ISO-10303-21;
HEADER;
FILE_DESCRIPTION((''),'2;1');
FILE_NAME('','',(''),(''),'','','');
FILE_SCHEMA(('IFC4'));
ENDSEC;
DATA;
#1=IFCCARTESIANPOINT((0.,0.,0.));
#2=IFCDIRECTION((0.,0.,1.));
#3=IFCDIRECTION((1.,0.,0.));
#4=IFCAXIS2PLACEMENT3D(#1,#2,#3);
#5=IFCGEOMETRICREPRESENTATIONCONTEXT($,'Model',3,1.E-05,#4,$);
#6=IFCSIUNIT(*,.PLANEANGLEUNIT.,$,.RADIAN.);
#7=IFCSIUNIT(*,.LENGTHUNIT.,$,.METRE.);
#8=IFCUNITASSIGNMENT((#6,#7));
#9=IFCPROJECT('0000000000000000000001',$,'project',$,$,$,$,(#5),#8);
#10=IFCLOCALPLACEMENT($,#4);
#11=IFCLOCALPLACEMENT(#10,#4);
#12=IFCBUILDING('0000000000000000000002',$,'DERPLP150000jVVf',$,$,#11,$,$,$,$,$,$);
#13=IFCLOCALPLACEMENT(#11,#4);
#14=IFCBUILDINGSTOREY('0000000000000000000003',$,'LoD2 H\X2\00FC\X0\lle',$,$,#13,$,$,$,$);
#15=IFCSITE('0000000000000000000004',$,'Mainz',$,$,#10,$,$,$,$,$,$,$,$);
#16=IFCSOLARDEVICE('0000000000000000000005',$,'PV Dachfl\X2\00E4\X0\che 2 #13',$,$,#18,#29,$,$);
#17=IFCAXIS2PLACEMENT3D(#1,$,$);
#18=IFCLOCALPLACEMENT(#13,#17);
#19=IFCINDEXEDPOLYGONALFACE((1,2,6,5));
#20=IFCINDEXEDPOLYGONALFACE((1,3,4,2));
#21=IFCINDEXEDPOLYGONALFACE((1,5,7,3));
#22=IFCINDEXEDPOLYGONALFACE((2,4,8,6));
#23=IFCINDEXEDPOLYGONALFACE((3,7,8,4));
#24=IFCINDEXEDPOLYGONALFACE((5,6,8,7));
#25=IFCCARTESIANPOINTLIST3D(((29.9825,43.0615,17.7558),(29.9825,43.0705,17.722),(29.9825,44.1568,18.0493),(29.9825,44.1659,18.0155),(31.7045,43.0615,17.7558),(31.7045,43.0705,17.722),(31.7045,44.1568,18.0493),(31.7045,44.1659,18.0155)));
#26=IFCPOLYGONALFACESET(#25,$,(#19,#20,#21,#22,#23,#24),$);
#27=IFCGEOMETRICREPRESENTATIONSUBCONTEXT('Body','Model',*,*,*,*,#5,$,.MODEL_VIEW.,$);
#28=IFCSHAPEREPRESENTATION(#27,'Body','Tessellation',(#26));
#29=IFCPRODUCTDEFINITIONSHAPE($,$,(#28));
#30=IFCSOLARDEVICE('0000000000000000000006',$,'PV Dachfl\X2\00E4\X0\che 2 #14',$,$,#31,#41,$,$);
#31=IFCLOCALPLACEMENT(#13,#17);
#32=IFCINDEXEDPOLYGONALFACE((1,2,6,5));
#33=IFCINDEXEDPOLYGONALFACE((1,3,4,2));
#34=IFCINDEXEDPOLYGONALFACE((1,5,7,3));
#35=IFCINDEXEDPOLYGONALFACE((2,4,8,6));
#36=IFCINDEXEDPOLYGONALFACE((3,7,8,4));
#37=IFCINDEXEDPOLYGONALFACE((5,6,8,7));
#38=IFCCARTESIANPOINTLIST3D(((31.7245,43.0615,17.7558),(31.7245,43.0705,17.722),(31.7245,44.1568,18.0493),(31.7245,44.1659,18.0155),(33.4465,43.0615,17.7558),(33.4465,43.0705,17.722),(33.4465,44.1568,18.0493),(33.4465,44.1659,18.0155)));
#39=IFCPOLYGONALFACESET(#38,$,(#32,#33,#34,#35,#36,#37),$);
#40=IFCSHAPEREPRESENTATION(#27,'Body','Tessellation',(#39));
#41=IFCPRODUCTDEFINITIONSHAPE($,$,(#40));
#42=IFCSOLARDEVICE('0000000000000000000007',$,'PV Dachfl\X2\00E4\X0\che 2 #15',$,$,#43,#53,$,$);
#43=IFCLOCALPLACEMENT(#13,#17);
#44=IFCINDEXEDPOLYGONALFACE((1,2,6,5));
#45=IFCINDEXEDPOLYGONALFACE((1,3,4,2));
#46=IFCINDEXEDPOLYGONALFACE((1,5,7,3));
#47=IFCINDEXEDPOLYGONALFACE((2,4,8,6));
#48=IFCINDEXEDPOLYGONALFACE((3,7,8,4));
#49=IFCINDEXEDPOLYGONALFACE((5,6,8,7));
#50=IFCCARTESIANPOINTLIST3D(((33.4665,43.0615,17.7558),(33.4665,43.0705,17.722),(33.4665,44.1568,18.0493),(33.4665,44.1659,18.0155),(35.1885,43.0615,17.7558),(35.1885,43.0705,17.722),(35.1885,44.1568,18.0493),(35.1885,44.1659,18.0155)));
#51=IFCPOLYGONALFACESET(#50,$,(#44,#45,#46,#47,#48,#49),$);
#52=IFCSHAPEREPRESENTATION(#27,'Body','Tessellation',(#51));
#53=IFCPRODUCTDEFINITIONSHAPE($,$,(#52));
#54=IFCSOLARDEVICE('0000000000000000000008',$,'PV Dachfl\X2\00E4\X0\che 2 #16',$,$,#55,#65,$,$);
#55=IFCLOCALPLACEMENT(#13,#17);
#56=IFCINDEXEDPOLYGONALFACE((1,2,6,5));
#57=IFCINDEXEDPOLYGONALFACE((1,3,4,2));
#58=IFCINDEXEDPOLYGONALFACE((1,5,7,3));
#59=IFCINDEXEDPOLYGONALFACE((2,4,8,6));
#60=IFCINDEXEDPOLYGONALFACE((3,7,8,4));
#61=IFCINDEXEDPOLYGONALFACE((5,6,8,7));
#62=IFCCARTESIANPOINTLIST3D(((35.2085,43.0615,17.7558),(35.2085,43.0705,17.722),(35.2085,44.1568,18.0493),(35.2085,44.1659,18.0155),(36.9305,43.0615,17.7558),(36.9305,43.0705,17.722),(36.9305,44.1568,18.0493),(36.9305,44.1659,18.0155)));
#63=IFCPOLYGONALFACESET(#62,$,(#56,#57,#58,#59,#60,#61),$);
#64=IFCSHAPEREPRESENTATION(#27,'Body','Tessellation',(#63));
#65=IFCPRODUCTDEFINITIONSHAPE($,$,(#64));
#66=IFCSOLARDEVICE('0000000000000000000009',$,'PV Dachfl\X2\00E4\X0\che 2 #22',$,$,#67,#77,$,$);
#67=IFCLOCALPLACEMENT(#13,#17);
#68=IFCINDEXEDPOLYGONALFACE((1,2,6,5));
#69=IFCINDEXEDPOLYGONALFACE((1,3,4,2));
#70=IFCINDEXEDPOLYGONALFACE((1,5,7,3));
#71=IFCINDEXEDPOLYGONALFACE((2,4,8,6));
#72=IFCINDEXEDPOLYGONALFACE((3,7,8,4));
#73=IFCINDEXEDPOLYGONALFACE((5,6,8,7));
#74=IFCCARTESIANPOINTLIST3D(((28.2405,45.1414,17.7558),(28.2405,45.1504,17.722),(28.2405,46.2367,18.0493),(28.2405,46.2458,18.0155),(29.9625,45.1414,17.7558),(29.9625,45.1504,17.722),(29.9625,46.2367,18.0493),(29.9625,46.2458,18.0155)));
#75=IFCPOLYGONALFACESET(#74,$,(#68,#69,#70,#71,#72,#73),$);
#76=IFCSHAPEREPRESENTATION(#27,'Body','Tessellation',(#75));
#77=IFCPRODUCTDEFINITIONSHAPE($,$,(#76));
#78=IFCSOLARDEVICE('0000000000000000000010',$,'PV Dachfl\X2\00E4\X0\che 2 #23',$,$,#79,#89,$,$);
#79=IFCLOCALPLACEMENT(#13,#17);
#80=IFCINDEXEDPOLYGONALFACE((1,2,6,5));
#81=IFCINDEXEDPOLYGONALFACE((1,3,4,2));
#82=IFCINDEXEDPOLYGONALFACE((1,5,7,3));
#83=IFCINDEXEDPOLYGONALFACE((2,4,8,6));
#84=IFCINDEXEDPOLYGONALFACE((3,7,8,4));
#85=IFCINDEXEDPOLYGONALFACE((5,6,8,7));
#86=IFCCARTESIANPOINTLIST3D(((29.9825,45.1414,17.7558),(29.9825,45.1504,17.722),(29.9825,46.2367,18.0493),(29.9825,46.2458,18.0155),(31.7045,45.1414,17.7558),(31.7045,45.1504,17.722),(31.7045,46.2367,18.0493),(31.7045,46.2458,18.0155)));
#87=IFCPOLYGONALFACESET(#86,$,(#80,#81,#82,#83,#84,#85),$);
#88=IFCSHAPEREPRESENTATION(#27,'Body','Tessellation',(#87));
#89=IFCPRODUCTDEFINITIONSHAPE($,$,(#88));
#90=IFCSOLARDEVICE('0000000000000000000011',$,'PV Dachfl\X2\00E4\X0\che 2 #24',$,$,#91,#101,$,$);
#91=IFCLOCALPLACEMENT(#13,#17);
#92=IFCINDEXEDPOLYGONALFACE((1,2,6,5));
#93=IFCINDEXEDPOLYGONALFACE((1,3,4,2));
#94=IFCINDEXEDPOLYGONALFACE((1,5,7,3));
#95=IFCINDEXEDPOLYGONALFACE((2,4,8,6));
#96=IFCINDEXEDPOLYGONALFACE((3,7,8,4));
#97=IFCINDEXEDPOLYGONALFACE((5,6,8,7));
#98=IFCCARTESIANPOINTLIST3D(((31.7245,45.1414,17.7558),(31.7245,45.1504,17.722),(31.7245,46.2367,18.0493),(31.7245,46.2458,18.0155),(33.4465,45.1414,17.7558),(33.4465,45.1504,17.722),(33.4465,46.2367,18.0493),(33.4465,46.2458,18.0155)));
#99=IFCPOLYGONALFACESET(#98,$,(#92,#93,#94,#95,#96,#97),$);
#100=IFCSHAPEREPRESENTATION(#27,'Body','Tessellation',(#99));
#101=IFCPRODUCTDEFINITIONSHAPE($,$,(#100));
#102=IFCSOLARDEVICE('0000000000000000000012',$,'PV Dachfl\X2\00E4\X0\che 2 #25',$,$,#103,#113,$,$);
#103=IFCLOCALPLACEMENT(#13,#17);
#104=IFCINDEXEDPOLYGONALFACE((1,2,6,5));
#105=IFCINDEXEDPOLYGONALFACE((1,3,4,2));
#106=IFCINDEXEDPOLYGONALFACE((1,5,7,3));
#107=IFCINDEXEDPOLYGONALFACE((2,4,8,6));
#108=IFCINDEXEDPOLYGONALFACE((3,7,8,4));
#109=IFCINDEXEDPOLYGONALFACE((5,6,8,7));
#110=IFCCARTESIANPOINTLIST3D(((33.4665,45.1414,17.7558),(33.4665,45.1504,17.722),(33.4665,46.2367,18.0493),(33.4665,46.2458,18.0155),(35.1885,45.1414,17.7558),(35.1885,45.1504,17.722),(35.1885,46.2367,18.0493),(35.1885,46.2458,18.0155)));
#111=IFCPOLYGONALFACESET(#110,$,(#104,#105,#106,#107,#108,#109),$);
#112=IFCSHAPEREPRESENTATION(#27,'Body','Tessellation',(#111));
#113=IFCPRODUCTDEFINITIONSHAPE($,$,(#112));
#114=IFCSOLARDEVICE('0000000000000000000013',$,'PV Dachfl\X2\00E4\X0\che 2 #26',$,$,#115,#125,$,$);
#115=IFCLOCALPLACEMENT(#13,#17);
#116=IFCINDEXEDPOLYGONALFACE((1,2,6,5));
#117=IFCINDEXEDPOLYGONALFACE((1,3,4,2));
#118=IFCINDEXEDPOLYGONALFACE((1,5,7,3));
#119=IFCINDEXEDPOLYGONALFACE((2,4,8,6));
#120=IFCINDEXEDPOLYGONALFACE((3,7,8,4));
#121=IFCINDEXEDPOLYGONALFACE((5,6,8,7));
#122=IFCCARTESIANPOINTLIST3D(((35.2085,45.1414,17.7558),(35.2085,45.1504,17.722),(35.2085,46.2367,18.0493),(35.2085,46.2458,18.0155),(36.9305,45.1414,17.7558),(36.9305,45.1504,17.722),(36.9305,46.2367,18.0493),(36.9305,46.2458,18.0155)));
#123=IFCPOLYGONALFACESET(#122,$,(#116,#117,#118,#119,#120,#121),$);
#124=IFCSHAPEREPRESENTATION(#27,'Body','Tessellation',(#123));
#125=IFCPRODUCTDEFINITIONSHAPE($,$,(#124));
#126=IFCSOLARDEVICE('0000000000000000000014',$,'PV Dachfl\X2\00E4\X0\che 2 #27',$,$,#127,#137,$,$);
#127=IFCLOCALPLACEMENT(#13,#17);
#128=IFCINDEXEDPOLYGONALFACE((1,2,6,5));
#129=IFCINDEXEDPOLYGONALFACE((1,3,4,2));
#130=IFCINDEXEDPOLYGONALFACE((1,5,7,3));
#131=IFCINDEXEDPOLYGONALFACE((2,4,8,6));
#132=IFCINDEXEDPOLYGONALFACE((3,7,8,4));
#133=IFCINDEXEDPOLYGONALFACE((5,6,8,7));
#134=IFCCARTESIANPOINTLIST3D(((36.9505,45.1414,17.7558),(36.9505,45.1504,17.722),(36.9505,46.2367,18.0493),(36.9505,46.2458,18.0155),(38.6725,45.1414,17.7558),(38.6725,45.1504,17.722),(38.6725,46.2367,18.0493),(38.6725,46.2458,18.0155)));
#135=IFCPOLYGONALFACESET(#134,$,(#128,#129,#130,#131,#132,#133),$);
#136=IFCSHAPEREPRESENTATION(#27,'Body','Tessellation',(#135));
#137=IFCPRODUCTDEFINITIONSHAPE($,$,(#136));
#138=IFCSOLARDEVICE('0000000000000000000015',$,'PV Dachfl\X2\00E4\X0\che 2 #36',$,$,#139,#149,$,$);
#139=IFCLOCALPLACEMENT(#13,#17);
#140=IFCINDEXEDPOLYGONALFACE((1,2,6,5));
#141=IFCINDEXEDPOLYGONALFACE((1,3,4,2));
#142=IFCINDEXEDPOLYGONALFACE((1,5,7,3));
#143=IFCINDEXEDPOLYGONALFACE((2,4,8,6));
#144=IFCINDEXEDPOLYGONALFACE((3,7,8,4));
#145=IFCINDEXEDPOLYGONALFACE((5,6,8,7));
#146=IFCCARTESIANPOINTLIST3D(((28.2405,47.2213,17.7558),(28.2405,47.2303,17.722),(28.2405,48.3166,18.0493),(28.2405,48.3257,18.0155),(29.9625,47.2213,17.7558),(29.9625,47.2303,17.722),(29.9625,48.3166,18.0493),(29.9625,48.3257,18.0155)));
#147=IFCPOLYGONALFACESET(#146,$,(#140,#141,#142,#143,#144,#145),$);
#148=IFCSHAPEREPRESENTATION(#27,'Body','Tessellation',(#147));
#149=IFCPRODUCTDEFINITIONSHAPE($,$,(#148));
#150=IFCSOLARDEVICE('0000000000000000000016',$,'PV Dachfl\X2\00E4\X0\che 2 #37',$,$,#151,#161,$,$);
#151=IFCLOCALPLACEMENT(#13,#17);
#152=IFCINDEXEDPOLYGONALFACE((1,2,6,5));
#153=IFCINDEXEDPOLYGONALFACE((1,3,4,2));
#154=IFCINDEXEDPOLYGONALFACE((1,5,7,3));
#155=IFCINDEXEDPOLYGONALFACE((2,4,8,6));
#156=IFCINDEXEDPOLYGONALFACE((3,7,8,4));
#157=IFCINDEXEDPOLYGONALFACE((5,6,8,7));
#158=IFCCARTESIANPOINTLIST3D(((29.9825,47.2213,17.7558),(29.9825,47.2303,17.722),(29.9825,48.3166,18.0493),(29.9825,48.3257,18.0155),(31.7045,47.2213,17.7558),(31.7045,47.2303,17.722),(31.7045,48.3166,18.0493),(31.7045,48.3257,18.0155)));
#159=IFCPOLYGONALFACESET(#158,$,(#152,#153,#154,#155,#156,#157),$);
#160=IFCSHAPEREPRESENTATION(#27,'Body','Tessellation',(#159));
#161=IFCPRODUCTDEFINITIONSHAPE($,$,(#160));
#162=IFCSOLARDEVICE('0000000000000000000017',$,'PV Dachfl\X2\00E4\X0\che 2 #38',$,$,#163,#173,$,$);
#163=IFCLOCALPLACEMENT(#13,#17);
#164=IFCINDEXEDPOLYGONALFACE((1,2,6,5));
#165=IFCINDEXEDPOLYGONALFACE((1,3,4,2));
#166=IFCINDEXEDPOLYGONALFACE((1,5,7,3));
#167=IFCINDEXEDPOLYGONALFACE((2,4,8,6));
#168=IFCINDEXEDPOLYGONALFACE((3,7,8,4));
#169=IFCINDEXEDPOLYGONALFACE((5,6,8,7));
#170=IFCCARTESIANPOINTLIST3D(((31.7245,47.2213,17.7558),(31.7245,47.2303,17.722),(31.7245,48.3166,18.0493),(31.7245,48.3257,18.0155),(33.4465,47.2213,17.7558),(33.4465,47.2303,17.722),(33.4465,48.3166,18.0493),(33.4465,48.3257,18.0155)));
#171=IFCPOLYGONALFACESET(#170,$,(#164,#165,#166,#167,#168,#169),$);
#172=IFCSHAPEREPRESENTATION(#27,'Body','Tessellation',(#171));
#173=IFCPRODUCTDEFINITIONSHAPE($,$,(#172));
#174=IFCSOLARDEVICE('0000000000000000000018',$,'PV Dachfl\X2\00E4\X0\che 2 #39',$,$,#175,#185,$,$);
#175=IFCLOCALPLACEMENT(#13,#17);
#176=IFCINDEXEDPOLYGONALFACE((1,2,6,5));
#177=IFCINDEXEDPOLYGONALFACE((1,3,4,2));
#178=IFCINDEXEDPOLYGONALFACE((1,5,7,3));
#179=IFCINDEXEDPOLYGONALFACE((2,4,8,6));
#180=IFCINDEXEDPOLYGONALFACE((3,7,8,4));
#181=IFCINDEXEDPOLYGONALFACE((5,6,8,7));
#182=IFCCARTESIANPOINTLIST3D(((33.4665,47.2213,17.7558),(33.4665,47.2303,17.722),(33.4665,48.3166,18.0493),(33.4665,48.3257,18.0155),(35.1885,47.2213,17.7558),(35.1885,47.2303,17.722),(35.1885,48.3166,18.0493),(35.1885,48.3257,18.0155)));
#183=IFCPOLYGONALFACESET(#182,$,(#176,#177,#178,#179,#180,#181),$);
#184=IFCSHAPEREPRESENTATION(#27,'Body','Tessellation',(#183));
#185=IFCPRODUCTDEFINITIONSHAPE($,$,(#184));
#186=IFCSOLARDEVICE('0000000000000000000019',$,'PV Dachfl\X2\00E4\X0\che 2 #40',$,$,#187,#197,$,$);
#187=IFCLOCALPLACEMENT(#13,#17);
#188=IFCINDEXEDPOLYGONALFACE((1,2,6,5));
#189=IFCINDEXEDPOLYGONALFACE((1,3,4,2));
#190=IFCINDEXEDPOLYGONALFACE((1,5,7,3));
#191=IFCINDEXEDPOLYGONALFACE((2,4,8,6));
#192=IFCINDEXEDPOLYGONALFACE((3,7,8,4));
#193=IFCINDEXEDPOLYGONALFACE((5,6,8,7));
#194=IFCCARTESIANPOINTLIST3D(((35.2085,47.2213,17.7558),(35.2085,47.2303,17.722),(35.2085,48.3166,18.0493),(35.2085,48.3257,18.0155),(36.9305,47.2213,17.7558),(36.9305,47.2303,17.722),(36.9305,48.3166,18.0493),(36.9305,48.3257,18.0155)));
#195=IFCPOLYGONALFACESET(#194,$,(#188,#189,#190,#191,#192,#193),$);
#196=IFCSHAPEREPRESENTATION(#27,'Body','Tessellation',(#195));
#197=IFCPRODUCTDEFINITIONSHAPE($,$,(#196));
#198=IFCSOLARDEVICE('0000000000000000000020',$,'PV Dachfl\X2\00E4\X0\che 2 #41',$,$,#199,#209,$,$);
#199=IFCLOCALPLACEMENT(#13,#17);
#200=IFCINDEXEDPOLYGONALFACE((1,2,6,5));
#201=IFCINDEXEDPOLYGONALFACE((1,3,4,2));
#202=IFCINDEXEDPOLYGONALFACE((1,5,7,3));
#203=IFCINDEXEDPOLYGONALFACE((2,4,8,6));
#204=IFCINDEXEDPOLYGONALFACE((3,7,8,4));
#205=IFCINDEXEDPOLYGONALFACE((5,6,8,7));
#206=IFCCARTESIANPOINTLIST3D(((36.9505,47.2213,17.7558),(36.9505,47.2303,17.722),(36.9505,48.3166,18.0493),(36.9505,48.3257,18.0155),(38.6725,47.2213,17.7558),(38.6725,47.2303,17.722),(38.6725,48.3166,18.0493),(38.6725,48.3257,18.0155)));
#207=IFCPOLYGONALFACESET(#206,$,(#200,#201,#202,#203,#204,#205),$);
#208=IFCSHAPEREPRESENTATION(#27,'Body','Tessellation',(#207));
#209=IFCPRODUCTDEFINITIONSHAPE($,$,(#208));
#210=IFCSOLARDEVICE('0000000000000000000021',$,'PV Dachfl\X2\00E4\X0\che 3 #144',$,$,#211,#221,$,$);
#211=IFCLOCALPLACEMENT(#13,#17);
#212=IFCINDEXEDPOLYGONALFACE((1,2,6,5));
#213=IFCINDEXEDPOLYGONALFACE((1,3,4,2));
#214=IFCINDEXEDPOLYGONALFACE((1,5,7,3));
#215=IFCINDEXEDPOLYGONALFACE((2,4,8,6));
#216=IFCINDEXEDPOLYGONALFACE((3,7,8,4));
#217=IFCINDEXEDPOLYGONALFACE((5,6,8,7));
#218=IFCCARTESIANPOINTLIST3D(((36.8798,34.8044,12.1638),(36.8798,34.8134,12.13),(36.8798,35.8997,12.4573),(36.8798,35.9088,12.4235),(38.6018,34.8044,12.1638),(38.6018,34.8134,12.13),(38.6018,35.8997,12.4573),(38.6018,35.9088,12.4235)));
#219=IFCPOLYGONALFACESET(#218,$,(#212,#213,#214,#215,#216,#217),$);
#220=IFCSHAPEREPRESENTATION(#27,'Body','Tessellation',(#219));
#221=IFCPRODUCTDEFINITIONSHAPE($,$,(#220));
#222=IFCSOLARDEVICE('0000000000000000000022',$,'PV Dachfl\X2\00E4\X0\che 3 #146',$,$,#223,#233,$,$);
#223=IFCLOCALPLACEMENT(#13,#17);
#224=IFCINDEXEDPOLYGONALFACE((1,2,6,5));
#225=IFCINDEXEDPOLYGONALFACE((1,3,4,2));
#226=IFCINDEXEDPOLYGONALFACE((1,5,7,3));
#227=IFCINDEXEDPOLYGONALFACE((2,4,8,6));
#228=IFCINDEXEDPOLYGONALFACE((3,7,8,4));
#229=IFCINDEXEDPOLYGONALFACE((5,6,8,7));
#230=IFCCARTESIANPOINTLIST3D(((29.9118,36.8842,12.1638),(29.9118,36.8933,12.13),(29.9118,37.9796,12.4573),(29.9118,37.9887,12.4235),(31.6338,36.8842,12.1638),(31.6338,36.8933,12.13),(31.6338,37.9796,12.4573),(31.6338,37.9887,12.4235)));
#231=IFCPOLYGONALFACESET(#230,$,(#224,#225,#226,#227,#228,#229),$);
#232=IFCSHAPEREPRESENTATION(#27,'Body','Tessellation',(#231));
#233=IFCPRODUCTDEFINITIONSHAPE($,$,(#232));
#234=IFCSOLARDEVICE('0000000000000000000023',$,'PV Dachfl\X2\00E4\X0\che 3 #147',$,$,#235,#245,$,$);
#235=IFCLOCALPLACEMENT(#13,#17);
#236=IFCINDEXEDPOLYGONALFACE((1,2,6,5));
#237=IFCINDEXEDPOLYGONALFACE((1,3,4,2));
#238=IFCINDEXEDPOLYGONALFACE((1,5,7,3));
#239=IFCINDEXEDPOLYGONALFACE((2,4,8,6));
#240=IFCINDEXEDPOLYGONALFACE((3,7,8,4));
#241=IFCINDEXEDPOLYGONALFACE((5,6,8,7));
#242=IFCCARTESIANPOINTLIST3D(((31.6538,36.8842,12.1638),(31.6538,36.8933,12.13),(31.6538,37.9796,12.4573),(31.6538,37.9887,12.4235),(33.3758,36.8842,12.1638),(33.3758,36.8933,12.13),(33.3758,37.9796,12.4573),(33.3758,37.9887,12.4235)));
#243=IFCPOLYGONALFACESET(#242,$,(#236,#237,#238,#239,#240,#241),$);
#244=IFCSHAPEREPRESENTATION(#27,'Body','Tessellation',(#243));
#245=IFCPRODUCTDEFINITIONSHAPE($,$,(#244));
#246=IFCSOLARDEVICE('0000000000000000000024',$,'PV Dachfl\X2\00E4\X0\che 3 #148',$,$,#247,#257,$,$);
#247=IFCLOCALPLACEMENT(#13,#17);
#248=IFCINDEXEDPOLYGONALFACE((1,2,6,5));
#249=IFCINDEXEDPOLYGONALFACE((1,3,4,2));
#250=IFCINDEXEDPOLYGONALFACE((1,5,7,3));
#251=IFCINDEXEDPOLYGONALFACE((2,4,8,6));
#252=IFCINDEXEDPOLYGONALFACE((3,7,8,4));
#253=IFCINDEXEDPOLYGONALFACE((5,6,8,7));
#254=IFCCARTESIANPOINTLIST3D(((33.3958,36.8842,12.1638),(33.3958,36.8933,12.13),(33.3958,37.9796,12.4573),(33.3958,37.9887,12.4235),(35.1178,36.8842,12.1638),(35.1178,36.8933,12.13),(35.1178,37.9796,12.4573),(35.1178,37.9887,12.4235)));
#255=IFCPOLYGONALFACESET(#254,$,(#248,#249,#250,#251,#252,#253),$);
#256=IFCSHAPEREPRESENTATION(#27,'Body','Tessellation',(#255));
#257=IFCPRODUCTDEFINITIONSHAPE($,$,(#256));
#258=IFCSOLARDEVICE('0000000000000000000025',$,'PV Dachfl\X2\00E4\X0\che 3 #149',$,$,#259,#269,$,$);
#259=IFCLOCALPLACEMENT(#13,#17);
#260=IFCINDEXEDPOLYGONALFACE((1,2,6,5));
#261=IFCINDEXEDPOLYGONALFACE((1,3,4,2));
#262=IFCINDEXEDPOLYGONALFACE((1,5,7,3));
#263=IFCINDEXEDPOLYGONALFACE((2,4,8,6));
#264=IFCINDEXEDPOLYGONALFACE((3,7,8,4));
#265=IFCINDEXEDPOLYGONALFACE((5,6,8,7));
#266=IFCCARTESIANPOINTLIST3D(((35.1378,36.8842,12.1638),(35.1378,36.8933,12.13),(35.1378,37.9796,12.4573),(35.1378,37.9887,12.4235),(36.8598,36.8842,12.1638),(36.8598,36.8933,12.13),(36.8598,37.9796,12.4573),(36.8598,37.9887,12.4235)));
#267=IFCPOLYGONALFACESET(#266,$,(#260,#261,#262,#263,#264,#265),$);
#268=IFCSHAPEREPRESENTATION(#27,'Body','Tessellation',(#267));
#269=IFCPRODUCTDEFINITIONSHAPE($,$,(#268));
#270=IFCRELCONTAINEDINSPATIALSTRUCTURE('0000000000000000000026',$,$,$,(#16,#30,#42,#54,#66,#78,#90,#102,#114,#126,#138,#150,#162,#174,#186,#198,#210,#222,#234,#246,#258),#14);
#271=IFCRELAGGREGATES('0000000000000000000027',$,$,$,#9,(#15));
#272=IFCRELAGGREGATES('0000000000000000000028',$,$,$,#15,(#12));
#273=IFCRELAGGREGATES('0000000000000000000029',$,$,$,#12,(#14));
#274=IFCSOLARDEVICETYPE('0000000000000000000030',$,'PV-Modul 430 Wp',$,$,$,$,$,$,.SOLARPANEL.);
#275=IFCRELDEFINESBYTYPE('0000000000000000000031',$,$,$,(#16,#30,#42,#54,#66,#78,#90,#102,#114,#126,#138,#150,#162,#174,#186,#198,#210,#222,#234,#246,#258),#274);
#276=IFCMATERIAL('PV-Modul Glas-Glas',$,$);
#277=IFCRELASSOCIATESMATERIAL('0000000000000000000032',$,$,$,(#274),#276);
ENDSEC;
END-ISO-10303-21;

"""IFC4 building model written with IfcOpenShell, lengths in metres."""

from ifc_helpers import new_model, si_unit, frame, frame_2d, origin, origin_with_axes, place, context, subcontext, project, spatial, rectangle, extrude, source, transform, mapped, material, type_object, type_shapes, element, save


model = new_model("IFC4")

# Units and contexts
model_context = context("Model", 3, precision=1e-05, world=origin_with_axes())
body_context = subcontext(model_context, "Body", "Model", "MODEL_VIEW")
ifc_project = project(units=[si_unit("PLANEANGLEUNIT", "RADIAN"), si_unit("LENGTHUNIT", "METRE")], contexts=[model_context])

# Site, building, storey
site_placement = place(None, origin_with_axes())
site = spatial("IfcSite", under=ifc_project, at=site_placement, Name="Mainz")
building_placement = place(site_placement, origin_with_axes())
building = spatial("IfcBuilding", under=site, at=building_placement, Name="DERPLP150000jVVf")
storey_placement = place(building_placement, origin_with_axes())
storey = spatial("IfcBuildingStorey", under=building, at=storey_placement, Name="LoD2 Hülle")

# Solar devices
ifc_material = material(Name="PV-Modul Glas-Glas")
solar_device_type = type_object("IfcSolarDeviceType", Name="PV-Modul 430 Wp", PredefinedType="SOLARPANEL", material=ifc_material)
shared_shape = source(origin_with_axes(), body_context, "Body", "SweptSolid", [
    extrude(rectangle(XDim=1.722, YDim=1.134, at=frame_2d((0.861, 0.567))), origin(), (0.0, 0.0, 1.0), 0.035),
])
type_shapes(solar_device_type, [shared_shape])
for number, where, z_axis, x_axis, name in (
    (1, (29.9825, 43.0705, 17.722), (0.0, -0.258819, 0.965926), (1.0, 0.0, 0.0), "PV Dachfläche 2 #13"),
    (2, (31.7245, 43.0705, 17.722), (0.0, -0.258819, 0.965926), (1.0, 0.0, 0.0), "PV Dachfläche 2 #14"),
    (3, (33.4665, 43.0705, 17.722), (0.0, -0.258819, 0.965926), (1.0, 0.0, 0.0), "PV Dachfläche 2 #15"),
    (4, (35.2085, 43.0705, 17.722), (0.0, -0.258819, 0.965926), (1.0, 0.0, 0.0), "PV Dachfläche 2 #16"),
    (5, (28.2405, 45.1504, 17.722), (0.0, -0.258819, 0.965926), (1.0, 0.0, 0.0), "PV Dachfläche 2 #22"),
    (6, (29.9825, 45.1504, 17.722), (0.0, -0.258819, 0.965926), (1.0, 0.0, 0.0), "PV Dachfläche 2 #23"),
    (7, (31.7245, 45.1504, 17.722), (0.0, -0.258819, 0.965926), (1.0, 0.0, 0.0), "PV Dachfläche 2 #24"),
    (8, (33.4665, 45.1504, 17.722), (0.0, -0.258819, 0.965926), (1.0, 0.0, 0.0), "PV Dachfläche 2 #25"),
    (9, (35.2085, 45.1504, 17.722), (0.0, -0.258819, 0.965926), (1.0, 0.0, 0.0), "PV Dachfläche 2 #26"),
    (10, (36.9505, 45.1504, 17.722), (0.0, -0.258819, 0.965926), (1.0, 0.0, 0.0), "PV Dachfläche 2 #27"),
    (11, (28.2405, 47.2303, 17.722), (0.0, -0.258819, 0.965926), (1.0, 0.0, 0.0), "PV Dachfläche 2 #36"),
    (12, (29.9825, 47.2303, 17.722), (0.0, -0.258819, 0.965926), (1.0, 0.0, 0.0), "PV Dachfläche 2 #37"),
    (13, (31.7245, 47.2303, 17.722), (0.0, -0.258819, 0.965926), (1.0, 0.0, 0.0), "PV Dachfläche 2 #38"),
    (14, (33.4665, 47.2303, 17.722), (0.0, -0.258819, 0.965926), (1.0, 0.0, 0.0), "PV Dachfläche 2 #39"),
    (15, (35.2085, 47.2303, 17.722), (0.0, -0.258819, 0.965926), (1.0, 0.0, 0.0), "PV Dachfläche 2 #40"),
    (16, (36.9505, 47.2303, 17.722), (0.0, -0.258819, 0.965926), (1.0, 0.0, 0.0), "PV Dachfläche 2 #41"),
    (17, (36.8798, 34.8134, 12.13), (0.0, -0.258819, 0.965926), (1.0, 0.0, 0.0), "PV Dachfläche 3 #144"),
    (18, (29.9118, 36.8933, 12.13), (0.0, -0.258819, 0.965926), (1.0, 0.0, 0.0), "PV Dachfläche 3 #146"),
    (19, (31.6538, 36.8933, 12.13), (0.0, -0.258819, 0.965926), (1.0, 0.0, 0.0), "PV Dachfläche 3 #147"),
    (20, (33.3958, 36.8933, 12.13), (0.0, -0.258819, 0.965926), (1.0, 0.0, 0.0), "PV Dachfläche 3 #148"),
    (21, (35.1378, 36.8933, 12.13), (0.0, -0.258819, 0.965926), (1.0, 0.0, 0.0), "PV Dachfläche 3 #149"),
):
    element("IfcSolarDevice", number, at=place(storey_placement, frame(where, z_axis=z_axis, x_axis=x_axis)), inside=storey, type_object=solar_device_type, Name=name, context=body_context, shape_type="MappedRepresentation", body=[
        mapped(shared_shape, transform((0.0, 0.0, 0.0), x_axis=(1.0, 0.0, 0.0), y_axis=(0.0, 1.0, 0.0), z_axis=(0.0, 0.0, 1.0), scale=1.0)),
    ])

save(model, "model.ifc")
